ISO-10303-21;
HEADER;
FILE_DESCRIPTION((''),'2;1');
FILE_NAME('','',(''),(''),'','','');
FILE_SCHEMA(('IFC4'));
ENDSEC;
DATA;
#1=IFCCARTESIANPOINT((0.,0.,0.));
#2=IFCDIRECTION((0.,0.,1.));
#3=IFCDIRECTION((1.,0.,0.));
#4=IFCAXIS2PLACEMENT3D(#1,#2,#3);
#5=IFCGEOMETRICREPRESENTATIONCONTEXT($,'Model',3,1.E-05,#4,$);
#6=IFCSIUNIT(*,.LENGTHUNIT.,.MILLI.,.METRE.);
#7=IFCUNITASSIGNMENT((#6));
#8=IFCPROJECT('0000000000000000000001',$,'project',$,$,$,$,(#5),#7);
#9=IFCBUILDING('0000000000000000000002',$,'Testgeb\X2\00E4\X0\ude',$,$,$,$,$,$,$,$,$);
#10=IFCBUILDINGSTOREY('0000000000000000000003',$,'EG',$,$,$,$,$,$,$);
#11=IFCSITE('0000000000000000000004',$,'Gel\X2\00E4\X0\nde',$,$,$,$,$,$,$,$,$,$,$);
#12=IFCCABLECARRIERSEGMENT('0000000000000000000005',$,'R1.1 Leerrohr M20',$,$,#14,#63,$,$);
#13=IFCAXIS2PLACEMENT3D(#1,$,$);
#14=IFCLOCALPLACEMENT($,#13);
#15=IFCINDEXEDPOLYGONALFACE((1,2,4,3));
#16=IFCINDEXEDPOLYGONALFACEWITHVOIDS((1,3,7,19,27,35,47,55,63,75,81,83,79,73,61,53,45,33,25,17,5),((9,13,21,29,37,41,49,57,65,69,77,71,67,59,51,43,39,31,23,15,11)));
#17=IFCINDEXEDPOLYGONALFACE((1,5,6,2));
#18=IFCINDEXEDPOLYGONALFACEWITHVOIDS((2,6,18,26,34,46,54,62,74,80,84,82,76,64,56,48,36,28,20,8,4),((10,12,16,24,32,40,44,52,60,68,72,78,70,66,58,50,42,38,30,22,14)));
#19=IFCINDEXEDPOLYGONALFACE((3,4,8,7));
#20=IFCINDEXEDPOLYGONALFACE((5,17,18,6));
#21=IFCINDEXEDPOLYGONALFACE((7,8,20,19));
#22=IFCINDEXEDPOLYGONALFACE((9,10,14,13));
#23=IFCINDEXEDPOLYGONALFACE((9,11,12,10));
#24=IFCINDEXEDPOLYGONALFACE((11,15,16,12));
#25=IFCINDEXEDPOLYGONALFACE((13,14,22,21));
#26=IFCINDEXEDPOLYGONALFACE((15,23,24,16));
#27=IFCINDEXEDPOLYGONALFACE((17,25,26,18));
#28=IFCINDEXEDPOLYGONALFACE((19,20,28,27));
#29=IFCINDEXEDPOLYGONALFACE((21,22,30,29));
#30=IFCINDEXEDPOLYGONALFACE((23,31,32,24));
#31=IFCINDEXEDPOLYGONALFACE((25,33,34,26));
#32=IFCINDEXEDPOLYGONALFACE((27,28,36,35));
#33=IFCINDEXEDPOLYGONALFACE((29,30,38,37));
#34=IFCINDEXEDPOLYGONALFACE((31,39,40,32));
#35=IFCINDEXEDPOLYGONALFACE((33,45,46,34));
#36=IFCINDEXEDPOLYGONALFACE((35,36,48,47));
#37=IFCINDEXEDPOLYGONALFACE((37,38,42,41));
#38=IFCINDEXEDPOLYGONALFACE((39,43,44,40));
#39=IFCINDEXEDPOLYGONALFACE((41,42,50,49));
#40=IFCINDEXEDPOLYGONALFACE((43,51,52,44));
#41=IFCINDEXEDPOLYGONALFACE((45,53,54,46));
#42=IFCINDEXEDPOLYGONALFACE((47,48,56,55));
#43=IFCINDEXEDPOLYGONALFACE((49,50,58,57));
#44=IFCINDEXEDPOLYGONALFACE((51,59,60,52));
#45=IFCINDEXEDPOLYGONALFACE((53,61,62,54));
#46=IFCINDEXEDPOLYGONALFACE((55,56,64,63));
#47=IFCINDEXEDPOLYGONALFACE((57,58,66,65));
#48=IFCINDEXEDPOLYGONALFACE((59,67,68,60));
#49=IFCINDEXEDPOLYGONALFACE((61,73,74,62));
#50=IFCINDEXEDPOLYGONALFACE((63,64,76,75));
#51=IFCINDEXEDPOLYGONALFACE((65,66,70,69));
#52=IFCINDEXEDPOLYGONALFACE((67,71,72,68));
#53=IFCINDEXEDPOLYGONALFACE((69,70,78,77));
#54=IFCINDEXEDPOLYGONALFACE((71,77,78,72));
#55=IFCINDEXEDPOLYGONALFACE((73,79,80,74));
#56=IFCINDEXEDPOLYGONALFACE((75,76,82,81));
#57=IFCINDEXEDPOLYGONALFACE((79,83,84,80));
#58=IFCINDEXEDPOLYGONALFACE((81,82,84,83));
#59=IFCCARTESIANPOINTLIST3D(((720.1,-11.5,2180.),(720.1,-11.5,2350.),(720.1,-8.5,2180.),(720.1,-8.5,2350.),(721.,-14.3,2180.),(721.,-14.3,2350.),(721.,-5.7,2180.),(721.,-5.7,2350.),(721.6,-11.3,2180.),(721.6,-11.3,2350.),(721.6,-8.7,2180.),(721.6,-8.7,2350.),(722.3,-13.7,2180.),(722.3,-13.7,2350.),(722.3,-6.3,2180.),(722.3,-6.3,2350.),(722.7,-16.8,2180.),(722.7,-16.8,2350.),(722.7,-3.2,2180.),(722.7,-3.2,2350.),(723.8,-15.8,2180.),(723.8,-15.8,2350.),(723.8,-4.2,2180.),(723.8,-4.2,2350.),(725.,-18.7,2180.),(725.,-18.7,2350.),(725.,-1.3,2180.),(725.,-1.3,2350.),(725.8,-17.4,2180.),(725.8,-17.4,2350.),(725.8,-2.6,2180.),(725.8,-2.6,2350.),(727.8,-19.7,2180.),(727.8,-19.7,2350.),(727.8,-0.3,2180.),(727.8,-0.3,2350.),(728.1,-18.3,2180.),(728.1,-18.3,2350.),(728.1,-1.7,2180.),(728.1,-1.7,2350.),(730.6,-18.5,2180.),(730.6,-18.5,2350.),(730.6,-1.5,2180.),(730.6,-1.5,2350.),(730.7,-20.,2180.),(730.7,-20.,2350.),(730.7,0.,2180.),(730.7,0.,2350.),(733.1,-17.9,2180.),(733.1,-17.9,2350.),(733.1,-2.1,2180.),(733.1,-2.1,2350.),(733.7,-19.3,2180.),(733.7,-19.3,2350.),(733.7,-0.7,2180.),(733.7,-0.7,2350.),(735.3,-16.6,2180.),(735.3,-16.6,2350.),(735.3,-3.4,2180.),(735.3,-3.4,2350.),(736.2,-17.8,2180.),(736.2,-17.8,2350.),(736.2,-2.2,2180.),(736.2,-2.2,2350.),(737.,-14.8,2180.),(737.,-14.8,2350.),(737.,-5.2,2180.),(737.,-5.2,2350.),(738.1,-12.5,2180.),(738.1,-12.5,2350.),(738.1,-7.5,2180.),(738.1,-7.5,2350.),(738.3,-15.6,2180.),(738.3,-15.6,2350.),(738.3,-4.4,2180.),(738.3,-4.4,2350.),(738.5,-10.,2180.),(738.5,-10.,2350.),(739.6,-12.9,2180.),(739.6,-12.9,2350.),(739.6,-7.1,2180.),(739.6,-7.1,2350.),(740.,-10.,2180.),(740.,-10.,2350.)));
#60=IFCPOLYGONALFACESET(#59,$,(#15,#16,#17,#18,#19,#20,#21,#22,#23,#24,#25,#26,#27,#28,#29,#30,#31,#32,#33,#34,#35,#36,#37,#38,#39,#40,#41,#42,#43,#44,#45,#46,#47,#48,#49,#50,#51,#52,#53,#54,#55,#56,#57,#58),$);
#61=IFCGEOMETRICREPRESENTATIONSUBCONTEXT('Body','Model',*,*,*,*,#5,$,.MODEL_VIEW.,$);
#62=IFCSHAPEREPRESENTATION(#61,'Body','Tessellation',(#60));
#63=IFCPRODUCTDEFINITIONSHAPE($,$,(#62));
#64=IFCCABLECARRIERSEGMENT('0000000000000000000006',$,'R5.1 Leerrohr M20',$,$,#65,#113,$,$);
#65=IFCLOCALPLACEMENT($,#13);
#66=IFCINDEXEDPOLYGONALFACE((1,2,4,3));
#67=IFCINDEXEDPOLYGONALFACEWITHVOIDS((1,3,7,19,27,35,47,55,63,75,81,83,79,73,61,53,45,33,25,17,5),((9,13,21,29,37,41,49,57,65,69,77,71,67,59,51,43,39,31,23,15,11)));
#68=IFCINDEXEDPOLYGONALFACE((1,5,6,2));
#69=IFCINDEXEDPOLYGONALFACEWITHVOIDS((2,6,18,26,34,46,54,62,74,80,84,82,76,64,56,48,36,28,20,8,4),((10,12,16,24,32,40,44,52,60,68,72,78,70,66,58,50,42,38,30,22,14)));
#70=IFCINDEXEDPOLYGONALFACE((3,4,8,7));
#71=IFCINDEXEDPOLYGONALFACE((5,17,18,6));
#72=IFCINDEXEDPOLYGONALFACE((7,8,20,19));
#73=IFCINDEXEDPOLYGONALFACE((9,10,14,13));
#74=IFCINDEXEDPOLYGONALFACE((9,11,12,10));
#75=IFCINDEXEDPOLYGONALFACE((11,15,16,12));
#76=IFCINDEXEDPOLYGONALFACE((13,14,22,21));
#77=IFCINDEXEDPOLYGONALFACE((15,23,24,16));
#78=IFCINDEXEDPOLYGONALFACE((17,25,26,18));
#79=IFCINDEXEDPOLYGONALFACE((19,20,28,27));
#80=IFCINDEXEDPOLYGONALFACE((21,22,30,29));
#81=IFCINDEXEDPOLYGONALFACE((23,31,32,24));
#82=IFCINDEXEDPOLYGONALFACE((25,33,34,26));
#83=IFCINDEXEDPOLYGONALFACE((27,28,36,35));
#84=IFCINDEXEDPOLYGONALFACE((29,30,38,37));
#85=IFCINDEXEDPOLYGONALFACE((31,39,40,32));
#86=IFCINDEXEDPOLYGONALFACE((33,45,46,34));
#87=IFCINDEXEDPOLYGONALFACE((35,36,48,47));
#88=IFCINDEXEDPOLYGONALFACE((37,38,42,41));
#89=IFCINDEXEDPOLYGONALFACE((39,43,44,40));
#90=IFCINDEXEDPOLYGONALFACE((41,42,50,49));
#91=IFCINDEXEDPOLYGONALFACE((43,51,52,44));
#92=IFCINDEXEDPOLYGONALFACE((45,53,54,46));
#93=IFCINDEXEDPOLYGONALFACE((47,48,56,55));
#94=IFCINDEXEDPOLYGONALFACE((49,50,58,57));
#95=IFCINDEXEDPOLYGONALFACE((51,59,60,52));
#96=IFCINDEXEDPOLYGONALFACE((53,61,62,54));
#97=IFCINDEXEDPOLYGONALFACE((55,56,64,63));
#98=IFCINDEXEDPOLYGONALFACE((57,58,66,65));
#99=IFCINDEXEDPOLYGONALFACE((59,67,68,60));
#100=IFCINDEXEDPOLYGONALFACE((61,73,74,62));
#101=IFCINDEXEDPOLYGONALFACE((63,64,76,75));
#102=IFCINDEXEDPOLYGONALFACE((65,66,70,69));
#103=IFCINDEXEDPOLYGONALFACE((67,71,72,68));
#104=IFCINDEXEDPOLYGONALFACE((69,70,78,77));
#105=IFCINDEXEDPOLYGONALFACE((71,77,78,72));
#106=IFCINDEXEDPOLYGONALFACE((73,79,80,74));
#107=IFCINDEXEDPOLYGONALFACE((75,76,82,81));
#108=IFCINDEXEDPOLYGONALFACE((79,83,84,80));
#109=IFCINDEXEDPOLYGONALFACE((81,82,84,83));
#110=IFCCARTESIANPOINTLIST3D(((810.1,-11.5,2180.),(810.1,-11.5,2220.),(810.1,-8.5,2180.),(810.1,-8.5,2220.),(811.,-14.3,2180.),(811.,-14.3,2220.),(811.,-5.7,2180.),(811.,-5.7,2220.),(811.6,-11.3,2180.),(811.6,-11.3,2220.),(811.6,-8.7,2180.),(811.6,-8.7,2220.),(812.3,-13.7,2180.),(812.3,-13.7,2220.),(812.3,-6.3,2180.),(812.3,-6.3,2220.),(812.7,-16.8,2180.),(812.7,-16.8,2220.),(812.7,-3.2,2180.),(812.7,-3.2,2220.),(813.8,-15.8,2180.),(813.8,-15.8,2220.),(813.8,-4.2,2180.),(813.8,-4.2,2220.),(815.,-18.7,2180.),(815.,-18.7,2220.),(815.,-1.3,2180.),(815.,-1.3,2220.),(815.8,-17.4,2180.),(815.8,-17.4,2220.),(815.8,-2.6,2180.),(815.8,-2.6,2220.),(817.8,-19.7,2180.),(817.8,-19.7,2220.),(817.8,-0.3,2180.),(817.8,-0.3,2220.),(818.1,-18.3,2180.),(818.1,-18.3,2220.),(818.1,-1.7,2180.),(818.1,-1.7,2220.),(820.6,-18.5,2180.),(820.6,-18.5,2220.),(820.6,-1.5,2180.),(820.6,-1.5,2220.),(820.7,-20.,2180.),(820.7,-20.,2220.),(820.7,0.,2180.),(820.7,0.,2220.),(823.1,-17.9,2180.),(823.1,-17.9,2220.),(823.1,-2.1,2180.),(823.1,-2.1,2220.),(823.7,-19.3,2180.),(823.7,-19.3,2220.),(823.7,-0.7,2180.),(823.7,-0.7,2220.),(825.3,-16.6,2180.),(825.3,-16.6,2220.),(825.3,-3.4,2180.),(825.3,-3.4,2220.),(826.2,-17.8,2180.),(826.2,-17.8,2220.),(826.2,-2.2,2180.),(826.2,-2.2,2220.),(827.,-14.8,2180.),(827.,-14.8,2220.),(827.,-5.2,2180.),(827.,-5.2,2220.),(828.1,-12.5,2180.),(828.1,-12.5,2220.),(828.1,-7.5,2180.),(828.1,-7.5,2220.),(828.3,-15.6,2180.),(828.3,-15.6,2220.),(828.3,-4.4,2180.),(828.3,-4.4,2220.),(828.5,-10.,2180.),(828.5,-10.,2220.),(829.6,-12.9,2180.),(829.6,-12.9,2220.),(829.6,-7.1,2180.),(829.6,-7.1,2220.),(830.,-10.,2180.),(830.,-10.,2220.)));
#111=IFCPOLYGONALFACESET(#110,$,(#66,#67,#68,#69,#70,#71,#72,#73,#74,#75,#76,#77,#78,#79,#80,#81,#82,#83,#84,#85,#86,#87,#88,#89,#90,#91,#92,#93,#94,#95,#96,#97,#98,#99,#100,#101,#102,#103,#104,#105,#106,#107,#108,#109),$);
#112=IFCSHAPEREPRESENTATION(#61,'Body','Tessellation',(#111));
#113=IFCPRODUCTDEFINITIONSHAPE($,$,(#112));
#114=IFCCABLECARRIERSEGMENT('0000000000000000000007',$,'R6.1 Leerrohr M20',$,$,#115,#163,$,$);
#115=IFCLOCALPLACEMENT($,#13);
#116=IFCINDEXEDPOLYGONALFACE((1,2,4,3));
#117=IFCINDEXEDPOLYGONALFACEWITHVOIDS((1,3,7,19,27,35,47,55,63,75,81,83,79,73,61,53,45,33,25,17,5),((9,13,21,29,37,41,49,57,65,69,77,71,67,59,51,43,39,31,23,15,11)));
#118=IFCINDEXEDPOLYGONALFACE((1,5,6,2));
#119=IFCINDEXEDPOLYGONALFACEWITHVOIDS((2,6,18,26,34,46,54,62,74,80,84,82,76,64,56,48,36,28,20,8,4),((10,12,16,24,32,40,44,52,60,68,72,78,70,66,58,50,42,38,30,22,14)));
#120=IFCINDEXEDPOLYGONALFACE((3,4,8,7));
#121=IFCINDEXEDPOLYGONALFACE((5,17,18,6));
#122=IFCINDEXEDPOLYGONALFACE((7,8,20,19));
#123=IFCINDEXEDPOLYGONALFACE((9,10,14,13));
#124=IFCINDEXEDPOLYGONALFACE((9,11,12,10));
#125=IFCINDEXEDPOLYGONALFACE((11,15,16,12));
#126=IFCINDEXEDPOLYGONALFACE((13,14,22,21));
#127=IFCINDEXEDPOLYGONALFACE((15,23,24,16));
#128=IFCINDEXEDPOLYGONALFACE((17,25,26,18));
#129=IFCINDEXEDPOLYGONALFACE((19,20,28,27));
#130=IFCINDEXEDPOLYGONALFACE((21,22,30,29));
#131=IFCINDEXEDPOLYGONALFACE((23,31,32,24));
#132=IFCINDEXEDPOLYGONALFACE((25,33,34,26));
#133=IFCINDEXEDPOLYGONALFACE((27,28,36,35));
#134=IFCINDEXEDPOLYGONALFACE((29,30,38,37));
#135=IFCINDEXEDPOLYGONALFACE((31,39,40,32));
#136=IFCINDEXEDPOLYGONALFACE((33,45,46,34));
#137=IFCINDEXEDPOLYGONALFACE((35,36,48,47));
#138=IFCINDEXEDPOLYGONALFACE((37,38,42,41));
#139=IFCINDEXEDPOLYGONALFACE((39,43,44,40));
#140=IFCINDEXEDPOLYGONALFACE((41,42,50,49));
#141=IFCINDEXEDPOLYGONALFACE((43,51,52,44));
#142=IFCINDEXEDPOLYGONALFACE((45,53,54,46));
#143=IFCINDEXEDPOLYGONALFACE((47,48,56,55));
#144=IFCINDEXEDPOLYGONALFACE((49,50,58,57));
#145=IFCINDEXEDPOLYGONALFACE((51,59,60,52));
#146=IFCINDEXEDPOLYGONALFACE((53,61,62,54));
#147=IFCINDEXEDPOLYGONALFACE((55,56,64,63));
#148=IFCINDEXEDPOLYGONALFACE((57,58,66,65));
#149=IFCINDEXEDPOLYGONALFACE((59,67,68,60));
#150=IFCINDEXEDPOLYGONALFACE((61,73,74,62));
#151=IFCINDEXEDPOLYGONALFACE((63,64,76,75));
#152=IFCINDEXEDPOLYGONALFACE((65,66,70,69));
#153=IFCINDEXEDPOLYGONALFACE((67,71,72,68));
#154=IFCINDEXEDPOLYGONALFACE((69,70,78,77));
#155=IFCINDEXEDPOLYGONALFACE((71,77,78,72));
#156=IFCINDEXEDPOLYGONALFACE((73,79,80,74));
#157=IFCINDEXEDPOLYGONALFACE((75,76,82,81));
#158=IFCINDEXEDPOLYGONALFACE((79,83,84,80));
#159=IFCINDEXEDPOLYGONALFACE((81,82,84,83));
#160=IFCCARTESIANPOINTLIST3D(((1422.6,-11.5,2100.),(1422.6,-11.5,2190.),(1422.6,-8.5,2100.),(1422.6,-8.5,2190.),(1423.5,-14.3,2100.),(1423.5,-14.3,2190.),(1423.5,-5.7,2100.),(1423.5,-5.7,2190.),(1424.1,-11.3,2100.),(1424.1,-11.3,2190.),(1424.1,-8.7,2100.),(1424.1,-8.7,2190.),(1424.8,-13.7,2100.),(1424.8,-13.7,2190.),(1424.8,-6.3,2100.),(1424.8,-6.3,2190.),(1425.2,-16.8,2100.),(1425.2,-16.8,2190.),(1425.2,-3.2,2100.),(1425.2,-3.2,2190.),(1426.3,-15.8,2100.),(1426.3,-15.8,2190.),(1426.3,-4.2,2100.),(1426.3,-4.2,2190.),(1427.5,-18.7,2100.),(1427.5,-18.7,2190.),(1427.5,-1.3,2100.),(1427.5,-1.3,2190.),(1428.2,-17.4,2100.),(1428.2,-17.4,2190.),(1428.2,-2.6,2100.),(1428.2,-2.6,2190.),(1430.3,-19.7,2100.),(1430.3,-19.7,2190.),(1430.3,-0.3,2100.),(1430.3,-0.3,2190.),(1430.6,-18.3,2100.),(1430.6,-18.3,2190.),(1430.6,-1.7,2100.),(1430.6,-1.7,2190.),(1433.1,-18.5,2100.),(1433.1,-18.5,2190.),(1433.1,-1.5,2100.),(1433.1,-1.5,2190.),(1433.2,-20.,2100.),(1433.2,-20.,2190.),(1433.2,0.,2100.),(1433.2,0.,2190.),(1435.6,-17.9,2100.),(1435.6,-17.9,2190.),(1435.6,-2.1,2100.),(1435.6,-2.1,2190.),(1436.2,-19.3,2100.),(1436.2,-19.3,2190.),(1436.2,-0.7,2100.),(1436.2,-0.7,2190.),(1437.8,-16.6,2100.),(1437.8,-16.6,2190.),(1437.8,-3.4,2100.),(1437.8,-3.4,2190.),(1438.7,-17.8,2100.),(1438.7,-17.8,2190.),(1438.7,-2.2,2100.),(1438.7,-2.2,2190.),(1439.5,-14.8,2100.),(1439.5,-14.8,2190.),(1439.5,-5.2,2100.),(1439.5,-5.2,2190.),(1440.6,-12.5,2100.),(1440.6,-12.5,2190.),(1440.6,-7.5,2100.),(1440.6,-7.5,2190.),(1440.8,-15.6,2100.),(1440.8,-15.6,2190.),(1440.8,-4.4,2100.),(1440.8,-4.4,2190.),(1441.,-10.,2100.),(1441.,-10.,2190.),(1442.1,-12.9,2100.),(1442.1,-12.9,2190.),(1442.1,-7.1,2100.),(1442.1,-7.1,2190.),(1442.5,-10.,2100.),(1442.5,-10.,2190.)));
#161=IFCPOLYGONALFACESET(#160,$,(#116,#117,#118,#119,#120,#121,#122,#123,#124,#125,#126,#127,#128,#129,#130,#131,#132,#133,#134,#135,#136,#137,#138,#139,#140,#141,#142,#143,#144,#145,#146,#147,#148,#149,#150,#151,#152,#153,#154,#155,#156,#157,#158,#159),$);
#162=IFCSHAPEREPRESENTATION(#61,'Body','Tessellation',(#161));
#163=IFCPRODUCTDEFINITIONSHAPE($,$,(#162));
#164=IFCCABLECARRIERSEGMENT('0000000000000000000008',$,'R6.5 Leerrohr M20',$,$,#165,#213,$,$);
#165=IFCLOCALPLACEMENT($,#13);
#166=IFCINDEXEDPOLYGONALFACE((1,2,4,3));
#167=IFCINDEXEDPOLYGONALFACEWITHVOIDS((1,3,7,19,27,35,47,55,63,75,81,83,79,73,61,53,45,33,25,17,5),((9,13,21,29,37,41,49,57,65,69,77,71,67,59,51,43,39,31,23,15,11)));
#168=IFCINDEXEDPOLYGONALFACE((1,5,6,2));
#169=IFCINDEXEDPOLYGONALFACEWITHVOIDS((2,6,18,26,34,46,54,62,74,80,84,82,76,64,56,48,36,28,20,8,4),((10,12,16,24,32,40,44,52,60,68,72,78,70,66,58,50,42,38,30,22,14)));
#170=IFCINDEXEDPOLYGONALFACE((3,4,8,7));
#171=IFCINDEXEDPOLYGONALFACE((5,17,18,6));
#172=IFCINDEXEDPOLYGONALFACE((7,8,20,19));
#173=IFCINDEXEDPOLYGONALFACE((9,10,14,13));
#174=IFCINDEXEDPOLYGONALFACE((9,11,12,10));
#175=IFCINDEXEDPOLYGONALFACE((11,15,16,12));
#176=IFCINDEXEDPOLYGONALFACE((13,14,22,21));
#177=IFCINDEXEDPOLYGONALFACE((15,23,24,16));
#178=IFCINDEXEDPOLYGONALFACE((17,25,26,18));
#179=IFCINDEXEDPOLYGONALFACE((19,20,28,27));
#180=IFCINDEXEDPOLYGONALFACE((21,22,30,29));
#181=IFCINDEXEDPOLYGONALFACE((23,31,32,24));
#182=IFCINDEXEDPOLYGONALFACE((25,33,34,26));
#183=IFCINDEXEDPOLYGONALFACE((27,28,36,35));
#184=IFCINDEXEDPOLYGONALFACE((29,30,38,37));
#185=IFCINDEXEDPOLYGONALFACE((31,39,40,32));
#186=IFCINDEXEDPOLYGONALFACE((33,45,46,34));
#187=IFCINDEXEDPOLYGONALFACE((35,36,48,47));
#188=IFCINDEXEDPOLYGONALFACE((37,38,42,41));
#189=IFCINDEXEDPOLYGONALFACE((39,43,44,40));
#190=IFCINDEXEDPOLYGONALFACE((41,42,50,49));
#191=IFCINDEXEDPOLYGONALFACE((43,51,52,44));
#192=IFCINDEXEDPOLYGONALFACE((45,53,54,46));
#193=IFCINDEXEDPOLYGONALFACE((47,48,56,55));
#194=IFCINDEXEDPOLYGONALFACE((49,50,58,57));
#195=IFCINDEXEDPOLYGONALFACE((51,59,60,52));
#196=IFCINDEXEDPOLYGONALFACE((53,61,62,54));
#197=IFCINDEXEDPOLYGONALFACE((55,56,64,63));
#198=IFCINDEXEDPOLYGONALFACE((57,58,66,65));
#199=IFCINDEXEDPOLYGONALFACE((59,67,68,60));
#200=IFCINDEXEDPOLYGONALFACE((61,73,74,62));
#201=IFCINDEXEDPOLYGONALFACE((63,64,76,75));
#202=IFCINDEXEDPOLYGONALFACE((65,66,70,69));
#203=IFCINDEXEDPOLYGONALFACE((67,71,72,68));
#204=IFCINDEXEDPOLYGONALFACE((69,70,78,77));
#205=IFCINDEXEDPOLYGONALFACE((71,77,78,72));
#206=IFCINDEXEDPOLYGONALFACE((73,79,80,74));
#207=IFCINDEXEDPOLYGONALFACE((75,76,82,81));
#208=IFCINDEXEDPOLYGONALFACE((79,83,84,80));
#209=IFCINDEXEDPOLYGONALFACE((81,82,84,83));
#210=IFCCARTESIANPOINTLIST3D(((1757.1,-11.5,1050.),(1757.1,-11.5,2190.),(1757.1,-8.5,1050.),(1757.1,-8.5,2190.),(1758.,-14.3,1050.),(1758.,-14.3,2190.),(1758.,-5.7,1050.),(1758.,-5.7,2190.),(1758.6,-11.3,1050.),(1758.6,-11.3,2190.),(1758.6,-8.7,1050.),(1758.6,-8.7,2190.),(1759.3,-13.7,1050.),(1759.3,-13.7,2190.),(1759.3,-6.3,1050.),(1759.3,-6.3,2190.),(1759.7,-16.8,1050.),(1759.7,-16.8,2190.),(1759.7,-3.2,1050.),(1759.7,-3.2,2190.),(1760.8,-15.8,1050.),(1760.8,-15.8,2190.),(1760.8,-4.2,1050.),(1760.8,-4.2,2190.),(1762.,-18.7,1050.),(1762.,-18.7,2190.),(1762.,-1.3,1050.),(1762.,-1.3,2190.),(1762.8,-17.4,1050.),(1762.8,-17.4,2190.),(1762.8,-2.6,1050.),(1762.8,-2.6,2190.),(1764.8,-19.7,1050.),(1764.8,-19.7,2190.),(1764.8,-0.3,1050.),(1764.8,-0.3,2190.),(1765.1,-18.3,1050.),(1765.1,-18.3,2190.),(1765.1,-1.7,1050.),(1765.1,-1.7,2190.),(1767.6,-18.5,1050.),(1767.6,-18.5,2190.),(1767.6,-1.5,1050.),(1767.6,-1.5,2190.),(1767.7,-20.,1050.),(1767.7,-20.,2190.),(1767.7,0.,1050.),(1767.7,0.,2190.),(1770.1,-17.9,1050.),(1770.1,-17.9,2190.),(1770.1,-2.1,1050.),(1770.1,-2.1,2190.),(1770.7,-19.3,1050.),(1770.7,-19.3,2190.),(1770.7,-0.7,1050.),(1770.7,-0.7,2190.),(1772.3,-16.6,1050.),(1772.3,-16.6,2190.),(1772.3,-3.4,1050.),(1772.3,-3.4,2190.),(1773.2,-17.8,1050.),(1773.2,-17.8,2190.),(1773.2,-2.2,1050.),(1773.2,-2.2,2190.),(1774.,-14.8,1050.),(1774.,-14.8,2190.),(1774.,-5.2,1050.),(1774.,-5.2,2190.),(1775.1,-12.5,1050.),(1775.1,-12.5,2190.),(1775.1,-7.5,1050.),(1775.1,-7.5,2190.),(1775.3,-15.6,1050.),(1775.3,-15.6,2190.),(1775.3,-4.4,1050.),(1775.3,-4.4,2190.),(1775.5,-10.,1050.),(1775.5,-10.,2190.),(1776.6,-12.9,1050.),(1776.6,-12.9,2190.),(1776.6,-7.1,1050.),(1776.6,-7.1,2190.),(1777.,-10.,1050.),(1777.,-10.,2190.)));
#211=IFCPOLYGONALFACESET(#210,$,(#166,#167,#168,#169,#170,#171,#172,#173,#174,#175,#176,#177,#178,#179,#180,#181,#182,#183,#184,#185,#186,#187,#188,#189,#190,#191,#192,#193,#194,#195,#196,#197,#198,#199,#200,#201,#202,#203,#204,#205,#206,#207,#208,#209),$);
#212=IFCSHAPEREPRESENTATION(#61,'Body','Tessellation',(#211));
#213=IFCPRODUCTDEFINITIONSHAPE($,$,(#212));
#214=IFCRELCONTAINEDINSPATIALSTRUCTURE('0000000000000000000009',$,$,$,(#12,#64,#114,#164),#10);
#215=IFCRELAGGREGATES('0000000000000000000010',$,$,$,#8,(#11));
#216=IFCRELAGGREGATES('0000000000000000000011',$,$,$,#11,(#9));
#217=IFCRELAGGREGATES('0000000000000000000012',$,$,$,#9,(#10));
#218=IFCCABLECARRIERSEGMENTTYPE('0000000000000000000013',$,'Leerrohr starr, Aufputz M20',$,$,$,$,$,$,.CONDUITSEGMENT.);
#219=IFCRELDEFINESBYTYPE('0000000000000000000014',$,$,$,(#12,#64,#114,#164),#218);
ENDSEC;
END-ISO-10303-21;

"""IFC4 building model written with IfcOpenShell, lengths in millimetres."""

from ifc_helpers import new_model, si_unit, frame, origin_with_axes, place, context, subcontext, project, spatial, hollow_circle, extrude, type_object, element, save


model = new_model("IFC4")

# Units and contexts
model_context = context("Model", 3, precision=1e-05, world=origin_with_axes())
body_context = subcontext(model_context, "Body", "Model", "MODEL_VIEW")
ifc_project = project(units=[si_unit("LENGTHUNIT", "METRE", prefix="MILLI")], contexts=[model_context])

# Site, building, storey
site = spatial("IfcSite", under=ifc_project, Name="Gelände")
building = spatial("IfcBuilding", under=site, Name="Testgebäude")
storey = spatial("IfcBuildingStorey", under=building, Name="EG")

# Cable carrier segments
cable_carrier_segment_type_1 = type_object("IfcCableCarrierSegmentType", Name="Leerrohr starr, Aufputz M20", PredefinedType="CONDUITSEGMENT")
cable_carrier_segment_1_placement = place(None, frame((730.0, -10.0, 2180.0), z_axis=(0.0, 0.0, 1.0), x_axis=(1.0, 0.0, 0.0)))
element("IfcCableCarrierSegment", 1, at=cable_carrier_segment_1_placement, inside=storey, type_object=cable_carrier_segment_type_1, Name="R1.1 Leerrohr M20", context=body_context, shape_type="SweptSolid", body=[
    extrude(hollow_circle(Radius=10.0, WallThickness=1.5), None, (0.0, 0.0, 1.0), 170.0),
])
cable_carrier_segment_2_placement = place(None, frame((820.0, -10.0, 2180.0), z_axis=(0.0, 0.0, 1.0), x_axis=(1.0, 0.0, 0.0)))
element("IfcCableCarrierSegment", 2, at=cable_carrier_segment_2_placement, inside=storey, type_object=cable_carrier_segment_type_1, Name="R5.1 Leerrohr M20", context=body_context, shape_type="SweptSolid", body=[
    extrude(hollow_circle(Radius=10.0, WallThickness=1.5), None, (0.0, 0.0, 1.0), 40.0),
])
cable_carrier_segment_3_placement = place(None, frame((1432.5, -10.0, 2100.0), z_axis=(0.0, 0.0, 1.0), x_axis=(1.0, 0.0, 0.0)))
element("IfcCableCarrierSegment", 3, at=cable_carrier_segment_3_placement, inside=storey, type_object=cable_carrier_segment_type_1, Name="R6.1 Leerrohr M20", context=body_context, shape_type="SweptSolid", body=[
    extrude(hollow_circle(Radius=10.0, WallThickness=1.5), None, (0.0, 0.0, 1.0), 90.0),
])
cable_carrier_segment_4_placement = place(None, frame((1767.0, -10.0, 2190.0), z_axis=(0.0, 0.0, -1.0), x_axis=(1.0, 0.0, 0.0)))
element("IfcCableCarrierSegment", 4, at=cable_carrier_segment_4_placement, inside=storey, type_object=cable_carrier_segment_type_1, Name="R6.5 Leerrohr M20", context=body_context, shape_type="SweptSolid", body=[
    extrude(hollow_circle(Radius=10.0, WallThickness=1.5), None, (0.0, 0.0, 1.0), 1140.0),
])

save(model, "model.ifc")
